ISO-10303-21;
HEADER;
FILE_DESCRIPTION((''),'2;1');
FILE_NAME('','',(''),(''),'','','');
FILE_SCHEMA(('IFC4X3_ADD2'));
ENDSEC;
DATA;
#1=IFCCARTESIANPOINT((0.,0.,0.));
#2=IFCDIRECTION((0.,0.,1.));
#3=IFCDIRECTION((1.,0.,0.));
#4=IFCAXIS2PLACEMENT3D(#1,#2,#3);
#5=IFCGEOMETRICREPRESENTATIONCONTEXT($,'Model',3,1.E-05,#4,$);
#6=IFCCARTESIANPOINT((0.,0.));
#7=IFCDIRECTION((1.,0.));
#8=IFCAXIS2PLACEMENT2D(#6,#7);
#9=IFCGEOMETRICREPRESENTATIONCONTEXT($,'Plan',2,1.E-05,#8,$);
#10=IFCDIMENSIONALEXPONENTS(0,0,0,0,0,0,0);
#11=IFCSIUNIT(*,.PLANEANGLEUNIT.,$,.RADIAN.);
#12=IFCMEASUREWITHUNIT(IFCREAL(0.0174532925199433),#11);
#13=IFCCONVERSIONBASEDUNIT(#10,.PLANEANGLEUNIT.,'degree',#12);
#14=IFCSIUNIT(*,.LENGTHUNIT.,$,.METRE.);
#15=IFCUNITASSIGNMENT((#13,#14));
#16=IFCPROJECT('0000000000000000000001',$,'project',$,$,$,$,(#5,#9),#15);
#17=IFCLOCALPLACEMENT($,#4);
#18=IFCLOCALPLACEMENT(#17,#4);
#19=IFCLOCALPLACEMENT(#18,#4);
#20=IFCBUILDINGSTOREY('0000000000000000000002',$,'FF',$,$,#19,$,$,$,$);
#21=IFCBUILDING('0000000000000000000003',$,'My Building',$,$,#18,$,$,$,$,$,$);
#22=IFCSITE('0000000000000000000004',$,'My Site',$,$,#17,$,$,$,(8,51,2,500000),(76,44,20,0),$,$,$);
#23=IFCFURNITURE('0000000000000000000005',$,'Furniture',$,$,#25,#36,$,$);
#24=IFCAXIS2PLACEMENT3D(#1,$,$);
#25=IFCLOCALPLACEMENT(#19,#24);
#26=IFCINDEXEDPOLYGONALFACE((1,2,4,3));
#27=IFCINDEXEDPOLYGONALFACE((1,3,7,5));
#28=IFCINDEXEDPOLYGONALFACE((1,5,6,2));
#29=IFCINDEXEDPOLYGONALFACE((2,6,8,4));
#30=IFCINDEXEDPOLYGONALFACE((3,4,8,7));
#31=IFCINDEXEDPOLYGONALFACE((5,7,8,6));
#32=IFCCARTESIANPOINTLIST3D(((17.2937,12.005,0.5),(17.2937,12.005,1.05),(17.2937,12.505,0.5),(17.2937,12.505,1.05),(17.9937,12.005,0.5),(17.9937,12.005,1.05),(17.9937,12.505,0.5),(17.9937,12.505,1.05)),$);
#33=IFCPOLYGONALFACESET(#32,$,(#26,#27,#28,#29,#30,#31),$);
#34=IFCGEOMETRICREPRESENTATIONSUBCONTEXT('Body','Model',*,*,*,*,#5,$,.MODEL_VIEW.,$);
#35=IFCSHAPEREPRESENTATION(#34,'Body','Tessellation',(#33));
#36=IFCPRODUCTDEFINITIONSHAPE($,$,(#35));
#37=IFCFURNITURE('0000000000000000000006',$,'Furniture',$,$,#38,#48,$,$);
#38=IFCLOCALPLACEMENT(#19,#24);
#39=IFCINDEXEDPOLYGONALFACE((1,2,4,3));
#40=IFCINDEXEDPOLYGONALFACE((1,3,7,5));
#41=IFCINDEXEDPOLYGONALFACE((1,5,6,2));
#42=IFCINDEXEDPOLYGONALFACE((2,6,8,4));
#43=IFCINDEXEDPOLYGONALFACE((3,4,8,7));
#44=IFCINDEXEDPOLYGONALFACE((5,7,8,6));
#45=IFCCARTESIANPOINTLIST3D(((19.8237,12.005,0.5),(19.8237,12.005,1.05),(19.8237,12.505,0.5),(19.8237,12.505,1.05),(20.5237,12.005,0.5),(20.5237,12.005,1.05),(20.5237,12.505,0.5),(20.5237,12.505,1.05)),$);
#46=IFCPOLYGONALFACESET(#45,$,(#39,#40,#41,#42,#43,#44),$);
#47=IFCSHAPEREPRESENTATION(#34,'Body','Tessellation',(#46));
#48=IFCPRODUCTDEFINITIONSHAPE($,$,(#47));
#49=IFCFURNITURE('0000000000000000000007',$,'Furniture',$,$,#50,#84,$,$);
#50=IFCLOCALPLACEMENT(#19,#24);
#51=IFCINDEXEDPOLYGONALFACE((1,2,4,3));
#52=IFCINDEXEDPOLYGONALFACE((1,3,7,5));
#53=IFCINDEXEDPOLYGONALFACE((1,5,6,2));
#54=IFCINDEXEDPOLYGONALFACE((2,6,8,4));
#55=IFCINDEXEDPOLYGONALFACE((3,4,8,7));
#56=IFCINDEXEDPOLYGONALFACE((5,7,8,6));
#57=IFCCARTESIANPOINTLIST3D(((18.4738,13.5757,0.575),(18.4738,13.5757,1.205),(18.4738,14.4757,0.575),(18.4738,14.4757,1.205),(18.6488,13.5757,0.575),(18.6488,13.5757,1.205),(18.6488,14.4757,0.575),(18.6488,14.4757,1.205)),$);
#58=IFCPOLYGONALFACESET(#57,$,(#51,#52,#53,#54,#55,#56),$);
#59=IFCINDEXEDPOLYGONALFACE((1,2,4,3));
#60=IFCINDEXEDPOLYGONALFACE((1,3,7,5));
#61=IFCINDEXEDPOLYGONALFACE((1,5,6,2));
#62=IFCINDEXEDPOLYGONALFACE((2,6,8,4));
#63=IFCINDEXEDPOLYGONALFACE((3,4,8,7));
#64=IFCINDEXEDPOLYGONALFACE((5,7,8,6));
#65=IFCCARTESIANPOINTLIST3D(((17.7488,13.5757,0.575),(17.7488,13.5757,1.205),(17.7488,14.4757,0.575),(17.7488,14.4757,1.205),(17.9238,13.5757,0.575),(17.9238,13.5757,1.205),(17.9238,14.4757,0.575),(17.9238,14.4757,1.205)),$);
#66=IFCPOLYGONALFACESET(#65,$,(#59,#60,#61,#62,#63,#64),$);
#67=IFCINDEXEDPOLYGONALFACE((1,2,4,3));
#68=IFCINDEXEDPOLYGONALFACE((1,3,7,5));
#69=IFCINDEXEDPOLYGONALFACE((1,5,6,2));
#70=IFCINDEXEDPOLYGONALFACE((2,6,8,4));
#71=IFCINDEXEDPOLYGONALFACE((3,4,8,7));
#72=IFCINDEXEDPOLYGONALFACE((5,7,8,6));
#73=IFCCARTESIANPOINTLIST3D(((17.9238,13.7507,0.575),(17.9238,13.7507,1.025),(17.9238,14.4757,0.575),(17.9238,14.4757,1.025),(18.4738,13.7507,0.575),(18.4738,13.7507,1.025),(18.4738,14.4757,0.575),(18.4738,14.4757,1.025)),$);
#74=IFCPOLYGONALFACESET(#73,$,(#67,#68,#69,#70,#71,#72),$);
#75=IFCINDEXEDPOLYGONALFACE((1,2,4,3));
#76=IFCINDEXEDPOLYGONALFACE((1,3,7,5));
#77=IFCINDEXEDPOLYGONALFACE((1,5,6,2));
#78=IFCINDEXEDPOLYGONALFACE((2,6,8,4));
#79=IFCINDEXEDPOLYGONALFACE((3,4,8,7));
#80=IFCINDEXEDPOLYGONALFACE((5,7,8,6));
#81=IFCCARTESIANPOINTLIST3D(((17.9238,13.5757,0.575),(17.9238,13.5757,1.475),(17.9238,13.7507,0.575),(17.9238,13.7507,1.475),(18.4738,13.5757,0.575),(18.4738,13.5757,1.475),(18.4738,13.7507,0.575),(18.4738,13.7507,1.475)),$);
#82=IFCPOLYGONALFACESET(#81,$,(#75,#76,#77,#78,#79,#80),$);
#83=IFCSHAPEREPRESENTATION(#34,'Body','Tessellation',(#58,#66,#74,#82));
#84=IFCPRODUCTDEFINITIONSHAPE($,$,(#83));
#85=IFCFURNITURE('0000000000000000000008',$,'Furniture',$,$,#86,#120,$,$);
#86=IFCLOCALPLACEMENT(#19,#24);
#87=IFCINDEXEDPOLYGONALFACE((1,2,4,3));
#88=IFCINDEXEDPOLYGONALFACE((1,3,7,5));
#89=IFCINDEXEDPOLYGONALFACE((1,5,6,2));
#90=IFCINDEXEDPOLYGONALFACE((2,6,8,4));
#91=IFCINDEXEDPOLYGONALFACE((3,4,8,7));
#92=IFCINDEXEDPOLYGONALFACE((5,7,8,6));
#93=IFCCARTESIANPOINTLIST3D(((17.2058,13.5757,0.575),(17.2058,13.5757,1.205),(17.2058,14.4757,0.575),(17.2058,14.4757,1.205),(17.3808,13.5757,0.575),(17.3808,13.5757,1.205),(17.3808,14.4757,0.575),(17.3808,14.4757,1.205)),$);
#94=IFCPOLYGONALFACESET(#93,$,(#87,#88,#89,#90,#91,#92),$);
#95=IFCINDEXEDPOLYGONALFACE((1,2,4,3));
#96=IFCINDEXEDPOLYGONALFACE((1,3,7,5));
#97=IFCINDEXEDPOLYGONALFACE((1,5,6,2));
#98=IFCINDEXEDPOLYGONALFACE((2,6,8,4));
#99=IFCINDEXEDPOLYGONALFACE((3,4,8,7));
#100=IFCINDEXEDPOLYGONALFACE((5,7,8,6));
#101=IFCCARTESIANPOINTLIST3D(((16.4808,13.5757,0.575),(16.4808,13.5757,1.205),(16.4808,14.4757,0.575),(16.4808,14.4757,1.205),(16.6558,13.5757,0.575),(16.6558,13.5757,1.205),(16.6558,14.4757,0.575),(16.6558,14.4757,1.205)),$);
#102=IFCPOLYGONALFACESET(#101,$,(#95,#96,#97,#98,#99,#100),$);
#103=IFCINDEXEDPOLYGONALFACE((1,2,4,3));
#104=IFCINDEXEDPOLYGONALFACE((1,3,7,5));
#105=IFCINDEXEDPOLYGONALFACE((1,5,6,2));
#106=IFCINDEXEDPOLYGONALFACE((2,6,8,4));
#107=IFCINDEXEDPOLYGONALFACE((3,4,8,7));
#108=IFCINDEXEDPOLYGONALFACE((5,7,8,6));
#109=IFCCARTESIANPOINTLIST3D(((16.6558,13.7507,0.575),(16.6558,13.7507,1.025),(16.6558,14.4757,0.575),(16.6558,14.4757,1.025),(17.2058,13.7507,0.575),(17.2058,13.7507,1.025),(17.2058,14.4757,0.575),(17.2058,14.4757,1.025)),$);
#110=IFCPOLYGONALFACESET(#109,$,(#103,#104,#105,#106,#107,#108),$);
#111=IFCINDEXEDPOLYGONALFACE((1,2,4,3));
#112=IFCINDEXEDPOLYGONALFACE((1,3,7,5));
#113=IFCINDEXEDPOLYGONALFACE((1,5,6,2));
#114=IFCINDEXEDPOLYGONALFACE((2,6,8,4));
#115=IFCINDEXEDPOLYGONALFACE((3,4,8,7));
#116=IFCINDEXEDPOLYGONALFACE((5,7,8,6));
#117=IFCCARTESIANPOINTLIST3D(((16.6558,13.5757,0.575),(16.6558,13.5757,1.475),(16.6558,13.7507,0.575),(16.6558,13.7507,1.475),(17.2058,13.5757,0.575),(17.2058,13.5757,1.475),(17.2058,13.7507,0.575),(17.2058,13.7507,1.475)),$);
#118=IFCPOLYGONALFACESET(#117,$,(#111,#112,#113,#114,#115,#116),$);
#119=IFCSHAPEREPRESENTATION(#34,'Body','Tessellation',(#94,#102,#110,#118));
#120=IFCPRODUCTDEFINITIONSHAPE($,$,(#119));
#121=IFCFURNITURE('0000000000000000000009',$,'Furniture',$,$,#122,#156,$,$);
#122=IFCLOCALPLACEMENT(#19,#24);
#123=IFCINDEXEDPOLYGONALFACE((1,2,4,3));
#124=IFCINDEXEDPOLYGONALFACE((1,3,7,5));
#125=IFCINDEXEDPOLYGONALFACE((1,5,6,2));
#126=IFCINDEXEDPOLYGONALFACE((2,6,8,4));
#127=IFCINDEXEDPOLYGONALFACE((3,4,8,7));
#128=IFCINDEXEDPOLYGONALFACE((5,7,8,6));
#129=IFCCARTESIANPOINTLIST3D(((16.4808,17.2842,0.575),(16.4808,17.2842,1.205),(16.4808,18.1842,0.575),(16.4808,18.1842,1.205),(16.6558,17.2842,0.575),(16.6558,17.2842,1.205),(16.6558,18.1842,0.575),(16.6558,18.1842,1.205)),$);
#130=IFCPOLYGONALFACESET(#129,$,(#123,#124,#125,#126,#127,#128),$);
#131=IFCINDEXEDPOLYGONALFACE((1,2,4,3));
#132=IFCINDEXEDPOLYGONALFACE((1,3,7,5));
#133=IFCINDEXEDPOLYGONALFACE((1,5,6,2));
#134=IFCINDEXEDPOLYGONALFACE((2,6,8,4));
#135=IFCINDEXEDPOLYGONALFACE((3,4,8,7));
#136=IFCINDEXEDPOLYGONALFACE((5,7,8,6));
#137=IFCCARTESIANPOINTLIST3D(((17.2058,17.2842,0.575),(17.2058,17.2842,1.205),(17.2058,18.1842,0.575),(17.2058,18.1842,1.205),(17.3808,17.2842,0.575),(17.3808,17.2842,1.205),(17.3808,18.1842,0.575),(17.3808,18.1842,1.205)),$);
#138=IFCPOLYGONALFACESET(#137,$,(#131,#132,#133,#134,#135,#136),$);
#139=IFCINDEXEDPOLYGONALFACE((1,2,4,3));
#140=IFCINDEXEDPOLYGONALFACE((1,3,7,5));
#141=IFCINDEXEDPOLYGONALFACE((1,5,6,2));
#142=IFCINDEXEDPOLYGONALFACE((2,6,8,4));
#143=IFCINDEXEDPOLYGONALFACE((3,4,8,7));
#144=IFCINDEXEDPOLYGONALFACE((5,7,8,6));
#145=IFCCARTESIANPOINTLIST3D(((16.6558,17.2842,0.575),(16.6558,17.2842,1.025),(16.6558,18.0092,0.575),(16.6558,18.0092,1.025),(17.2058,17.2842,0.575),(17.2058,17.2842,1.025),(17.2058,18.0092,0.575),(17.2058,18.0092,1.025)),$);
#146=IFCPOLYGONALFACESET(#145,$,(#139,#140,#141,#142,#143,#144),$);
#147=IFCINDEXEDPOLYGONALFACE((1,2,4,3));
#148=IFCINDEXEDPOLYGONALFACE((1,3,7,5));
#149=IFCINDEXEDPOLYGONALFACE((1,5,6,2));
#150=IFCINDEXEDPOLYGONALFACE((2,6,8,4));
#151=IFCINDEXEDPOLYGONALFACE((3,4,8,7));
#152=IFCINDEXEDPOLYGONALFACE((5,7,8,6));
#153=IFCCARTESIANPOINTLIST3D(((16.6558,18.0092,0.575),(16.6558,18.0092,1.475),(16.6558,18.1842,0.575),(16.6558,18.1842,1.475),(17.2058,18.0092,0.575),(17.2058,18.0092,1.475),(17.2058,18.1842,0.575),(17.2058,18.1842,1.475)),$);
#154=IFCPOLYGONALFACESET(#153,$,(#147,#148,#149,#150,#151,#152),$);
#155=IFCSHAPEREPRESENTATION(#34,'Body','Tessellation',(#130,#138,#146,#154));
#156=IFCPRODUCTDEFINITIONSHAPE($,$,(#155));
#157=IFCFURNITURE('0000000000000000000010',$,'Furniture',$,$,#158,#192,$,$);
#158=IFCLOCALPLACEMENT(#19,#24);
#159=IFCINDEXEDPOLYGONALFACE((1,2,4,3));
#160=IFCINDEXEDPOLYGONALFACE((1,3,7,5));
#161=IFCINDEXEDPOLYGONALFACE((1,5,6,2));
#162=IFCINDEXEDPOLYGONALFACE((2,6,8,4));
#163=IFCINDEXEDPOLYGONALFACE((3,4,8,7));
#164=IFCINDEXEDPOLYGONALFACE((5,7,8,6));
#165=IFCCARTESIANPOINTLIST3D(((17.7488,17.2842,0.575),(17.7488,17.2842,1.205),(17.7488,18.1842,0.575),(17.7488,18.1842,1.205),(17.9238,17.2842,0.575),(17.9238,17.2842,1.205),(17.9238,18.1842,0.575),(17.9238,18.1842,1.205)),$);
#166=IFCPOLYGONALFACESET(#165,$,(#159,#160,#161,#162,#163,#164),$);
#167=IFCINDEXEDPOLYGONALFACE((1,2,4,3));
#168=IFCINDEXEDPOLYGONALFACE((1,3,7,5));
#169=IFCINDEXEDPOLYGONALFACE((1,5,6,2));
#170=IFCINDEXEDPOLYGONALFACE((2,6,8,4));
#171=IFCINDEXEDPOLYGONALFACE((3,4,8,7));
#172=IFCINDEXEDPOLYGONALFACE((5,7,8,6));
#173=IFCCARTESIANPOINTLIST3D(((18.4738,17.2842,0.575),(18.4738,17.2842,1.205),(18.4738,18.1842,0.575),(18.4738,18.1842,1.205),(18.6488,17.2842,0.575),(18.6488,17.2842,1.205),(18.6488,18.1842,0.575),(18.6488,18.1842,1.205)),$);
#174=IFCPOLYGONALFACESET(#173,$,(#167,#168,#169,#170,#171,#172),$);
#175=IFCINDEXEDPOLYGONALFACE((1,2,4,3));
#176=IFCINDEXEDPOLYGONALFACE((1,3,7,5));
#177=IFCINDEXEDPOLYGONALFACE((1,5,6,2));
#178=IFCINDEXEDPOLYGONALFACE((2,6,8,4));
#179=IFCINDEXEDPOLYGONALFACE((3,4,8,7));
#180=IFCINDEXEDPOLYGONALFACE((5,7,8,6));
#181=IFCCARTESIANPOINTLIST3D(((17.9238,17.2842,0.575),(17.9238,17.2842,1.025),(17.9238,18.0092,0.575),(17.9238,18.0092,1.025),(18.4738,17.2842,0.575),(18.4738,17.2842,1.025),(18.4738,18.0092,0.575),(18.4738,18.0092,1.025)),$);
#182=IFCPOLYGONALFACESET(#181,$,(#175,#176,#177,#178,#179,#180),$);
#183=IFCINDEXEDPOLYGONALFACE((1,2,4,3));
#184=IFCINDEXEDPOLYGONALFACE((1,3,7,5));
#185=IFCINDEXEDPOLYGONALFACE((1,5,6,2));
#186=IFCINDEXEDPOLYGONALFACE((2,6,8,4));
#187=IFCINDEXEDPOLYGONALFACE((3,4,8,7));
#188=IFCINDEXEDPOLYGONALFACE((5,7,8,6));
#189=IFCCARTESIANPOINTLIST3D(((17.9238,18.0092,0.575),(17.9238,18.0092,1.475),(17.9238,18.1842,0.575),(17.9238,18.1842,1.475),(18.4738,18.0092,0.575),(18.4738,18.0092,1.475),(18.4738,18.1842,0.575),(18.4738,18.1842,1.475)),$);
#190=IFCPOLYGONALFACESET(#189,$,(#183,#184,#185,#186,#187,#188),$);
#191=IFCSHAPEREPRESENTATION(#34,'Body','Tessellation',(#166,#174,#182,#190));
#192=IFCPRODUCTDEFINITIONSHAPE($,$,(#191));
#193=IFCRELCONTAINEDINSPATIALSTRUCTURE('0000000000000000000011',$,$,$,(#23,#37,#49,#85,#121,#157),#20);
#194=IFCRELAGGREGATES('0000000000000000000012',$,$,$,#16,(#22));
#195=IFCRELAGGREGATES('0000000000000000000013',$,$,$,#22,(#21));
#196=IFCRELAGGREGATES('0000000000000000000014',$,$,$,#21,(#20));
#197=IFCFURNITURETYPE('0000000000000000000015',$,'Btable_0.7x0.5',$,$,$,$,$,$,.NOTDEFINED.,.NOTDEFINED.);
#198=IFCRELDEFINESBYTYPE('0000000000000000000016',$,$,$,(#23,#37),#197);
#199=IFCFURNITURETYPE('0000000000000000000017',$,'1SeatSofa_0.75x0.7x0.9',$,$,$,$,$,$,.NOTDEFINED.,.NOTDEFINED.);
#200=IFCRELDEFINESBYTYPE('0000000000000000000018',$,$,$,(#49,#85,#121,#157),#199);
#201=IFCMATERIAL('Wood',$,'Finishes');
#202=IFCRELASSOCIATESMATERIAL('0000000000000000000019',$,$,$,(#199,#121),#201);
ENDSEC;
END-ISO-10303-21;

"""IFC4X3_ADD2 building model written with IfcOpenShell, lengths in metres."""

from ifc_helpers import new_model, entity, si_unit, converted_unit, frame, origin_with_axes, origin_2d_with_axis, place, context, subcontext, project, spatial, line, indexed_curve, outline, extrude, shape, source, transform, mapped, material, type_object, type_shapes, element, save


model = new_model("IFC4X3_ADD2")

# Units and contexts
model_context = context("Model", 3, precision=1e-05, world=origin_with_axes())
plan_context = context("Plan", 2, precision=1e-05, world=origin_2d_with_axis())
body_context_1 = subcontext(model_context, "Body", "Model", "MODEL_VIEW")
body_context_2 = subcontext(plan_context, "Body", "Plan", "PLAN_VIEW")
ifc_project = project(units=[converted_unit("PLANEANGLEUNIT", "degree", entity("IfcReal", 0.0174532925199433), si_unit("PLANEANGLEUNIT", "RADIAN"), dimensions=[0, 0, 0, 0, 0, 0, 0]), si_unit("LENGTHUNIT", "METRE")], contexts=[model_context, plan_context])

# Site, building, storey
site_placement = place(None, origin_with_axes())
site = spatial("IfcSite", under=ifc_project, at=site_placement, Name="My Site", RefLatitude=(8, 51, 2, 500000), RefLongitude=(76, 44, 20, 0))
building_placement = place(site_placement, origin_with_axes())
building = spatial("IfcBuilding", under=site, at=building_placement, Name="My Building")
storey_placement = place(building_placement, origin_with_axes())
storey = spatial("IfcBuildingStorey", under=building, at=storey_placement, Name="FF")

# Furniture
furniture_type_1 = type_object("IfcFurnitureType", Name="Btable_0.7x0.5", AssemblyPlace="NOTDEFINED", PredefinedType="NOTDEFINED")
shared_shape_1 = source(origin_with_axes(), body_context_1, "Body", "SweptSolid", [
    extrude(outline(indexed_curve([(0.0, 0.0), (0.7, 0.0), (0.7, 0.5), (0.0, 0.5)], segments=[line(1, 2, 3, 4, 1)])), frame((-0.35, -0.25, 0.0), z_axis=(0.0, 0.0, 1.0), x_axis=(1.0, 0.0, 0.0)), (0.0, 0.0, 1.0), 0.55),
])
shared_shape_2 = source(origin_with_axes(), body_context_2, "Body", "Curve2D", [
    entity("IfcIndexedPolyCurve", entity("IfcCartesianPointList2D", [[-0.35, -0.25], [0.35, -0.25], [0.35, 0.25], [-0.35, 0.25]]), [entity("IfcLineIndex", [1, 2, 3, 4, 1])]),
])
type_shapes(furniture_type_1, [shared_shape_1, shared_shape_2])
for number, where, z_axis, x_axis, name in (
    (1, (17.6437, 12.255, 0.5), (0.0, 0.0, 1.0), (1.0, 0.0, 0.0), "Furniture"),
    (2, (20.1737, 12.255, 0.5), (0.0, 0.0, 1.0), (1.0, 0.0, 0.0), "Furniture"),
):
    element("IfcFurniture", number, at=place(storey_placement, frame(where, z_axis=z_axis, x_axis=x_axis)), inside=storey, type_object=furniture_type_1, Name=name, shapes=[
        shape(body_context_1, "Body", "MappedRepresentation", [mapped(shared_shape_1, transform((0.0, 0.0, 0.0), x_axis=(1.0, 0.0, 0.0), y_axis=(0.0, 1.0, 0.0), z_axis=(0.0, 0.0, 1.0), scale=1.0))]),
        shape(body_context_2, "Body", "MappedRepresentation", [mapped(shared_shape_2, transform((0.0, 0.0, 0.0), x_axis=(1.0, 0.0, 0.0), y_axis=(0.0, 1.0, 0.0), z_axis=(0.0, 0.0, 1.0), scale=1.0))]),
    ])
ifc_material_1 = material(Name="Wood", Category="Finishes")
furniture_type_2 = type_object("IfcFurnitureType", Name="1SeatSofa_0.75x0.7x0.9", AssemblyPlace="NOTDEFINED", PredefinedType="NOTDEFINED", material=ifc_material_1)
shared_shape_3 = source(origin_with_axes(), body_context_1, "Body", "SweptSolid", [
    extrude(outline(indexed_curve([(0.0, 0.0), (0.175, 0.0), (0.175, 0.9), (0.0, 0.9)], segments=[line(1, 2, 3, 4, 1)])), frame((-0.45, -0.9, 0.0), z_axis=(0.0, 0.0, 1.0), x_axis=(1.0, 0.0, 0.0)), (0.0, 0.0, 1.0), 0.63),
    extrude(outline(indexed_curve([(0.0, 0.0), (0.175, 0.0), (0.175, 0.9), (0.0, 0.9)], segments=[line(1, 2, 3, 4, 1)])), frame((0.275, -0.9, 0.0), z_axis=(0.0, 0.0, 1.0), x_axis=(1.0, 0.0, 0.0)), (0.0, 0.0, 1.0), 0.63),
    extrude(outline(indexed_curve([(0.175, 0.0), (0.725, 0.0), (0.725, 0.725), (0.175, 0.725)], segments=[line(1, 2, 3, 4, 1)])), frame((-0.45, -0.9, 0.0), z_axis=(0.0, 0.0, 1.0), x_axis=(1.0, 0.0, 0.0)), (0.0, 0.0, 1.0), 0.45),
    extrude(outline(indexed_curve([(0.175, 0.9), (0.175, 0.725), (0.725, 0.725), (0.725, 0.9), (0.175, 0.9)])), frame((-0.45, -0.9, 0.0), z_axis=(0.0, 0.0, 1.0), x_axis=(1.0, 0.0, 0.0)), (0.0, 0.0, 1.0), 0.9),
])
shared_shape_4 = source(origin_with_axes(), body_context_2, "Body", "Annotation2D", [
    entity("IfcGeometricCurveSet", [entity("IfcIndexedPolyCurve", entity("IfcCartesianPointList2D", [[0.275, -0.175], [0.275, -0.9], [0.45, -0.9], [0.45, 0.0], [0.275, 0.0], [0.275, -0.9], [-0.275, -0.9], [-0.275, 0.0], [-0.275, -0.175], [0.275, -0.175], [0.275, 0.0], [-0.275, 0.0], [-0.45, 0.0], [-0.45, -0.9], [-0.275, -0.9], [-0.275, -0.175]]))]),
])
type_shapes(furniture_type_2, [shared_shape_3, shared_shape_4])
for number, where, z_axis, x_axis, name in (
    (3, (18.1988, 13.5757, 0.575), (0.0, 0.0, 1.0), (-1.0, 0.000003, 0.0), "Furniture"),
    (4, (16.9308, 13.5757, 0.575), (0.0, 0.0, 1.0), (-1.0, 0.000003, 0.0), "Furniture"),
):
    element("IfcFurniture", number, at=place(storey_placement, frame(where, z_axis=z_axis, x_axis=x_axis)), inside=storey, type_object=furniture_type_2, Name=name, shapes=[
        shape(body_context_1, "Body", "MappedRepresentation", [mapped(shared_shape_3, transform((0.0, 0.0, 0.0), x_axis=(1.0, 0.0, 0.0), y_axis=(0.0, 1.0, 0.0), z_axis=(0.0, 0.0, 1.0), scale=1.0))]),
        shape(body_context_2, "Body", "MappedRepresentation", [mapped(shared_shape_4, transform((0.0, 0.0, 0.0), x_axis=(1.0, 0.0, 0.0), y_axis=(0.0, 1.0, 0.0), z_axis=(0.0, 0.0, 1.0), scale=1.0))]),
    ])
furniture_1_placement = place(storey_placement, frame((16.9308, 18.1842, 0.575), z_axis=(0.0, 0.0, 1.0), x_axis=(1.0, 0.0, 0.0)))
element("IfcFurniture", 5, at=furniture_1_placement, inside=storey, type_object=furniture_type_2, material=ifc_material_1, Name="Furniture", shapes=[
    shape(body_context_1, "Body", "MappedRepresentation", [mapped(shared_shape_3, transform((0.0, 0.0, 0.0), x_axis=(1.0, 0.0, 0.0), y_axis=(0.0, 1.0, 0.0), z_axis=(0.0, 0.0, 1.0), scale=1.0))]),
    shape(body_context_2, "Body", "MappedRepresentation", [mapped(shared_shape_4, transform((0.0, 0.0, 0.0), x_axis=(1.0, 0.0, 0.0), y_axis=(0.0, 1.0, 0.0), z_axis=(0.0, 0.0, 1.0), scale=1.0))]),
])
furniture_2_placement = place(storey_placement, frame((18.1988, 18.1842, 0.575), z_axis=(0.0, 0.0, 1.0), x_axis=(1.0, 0.0, 0.0)))
element("IfcFurniture", 6, at=furniture_2_placement, inside=storey, type_object=furniture_type_2, Name="Furniture", shapes=[
    shape(body_context_1, "Body", "MappedRepresentation", [mapped(shared_shape_3, transform((0.0, 0.0, 0.0), x_axis=(1.0, 0.0, 0.0), y_axis=(0.0, 1.0, 0.0), z_axis=(0.0, 0.0, 1.0), scale=1.0))]),
    shape(body_context_2, "Body", "MappedRepresentation", [mapped(shared_shape_4, transform((0.0, 0.0, 0.0), x_axis=(1.0, 0.0, 0.0), y_axis=(0.0, 1.0, 0.0), z_axis=(0.0, 0.0, 1.0), scale=1.0))]),
])

save(model, "model.ifc")
